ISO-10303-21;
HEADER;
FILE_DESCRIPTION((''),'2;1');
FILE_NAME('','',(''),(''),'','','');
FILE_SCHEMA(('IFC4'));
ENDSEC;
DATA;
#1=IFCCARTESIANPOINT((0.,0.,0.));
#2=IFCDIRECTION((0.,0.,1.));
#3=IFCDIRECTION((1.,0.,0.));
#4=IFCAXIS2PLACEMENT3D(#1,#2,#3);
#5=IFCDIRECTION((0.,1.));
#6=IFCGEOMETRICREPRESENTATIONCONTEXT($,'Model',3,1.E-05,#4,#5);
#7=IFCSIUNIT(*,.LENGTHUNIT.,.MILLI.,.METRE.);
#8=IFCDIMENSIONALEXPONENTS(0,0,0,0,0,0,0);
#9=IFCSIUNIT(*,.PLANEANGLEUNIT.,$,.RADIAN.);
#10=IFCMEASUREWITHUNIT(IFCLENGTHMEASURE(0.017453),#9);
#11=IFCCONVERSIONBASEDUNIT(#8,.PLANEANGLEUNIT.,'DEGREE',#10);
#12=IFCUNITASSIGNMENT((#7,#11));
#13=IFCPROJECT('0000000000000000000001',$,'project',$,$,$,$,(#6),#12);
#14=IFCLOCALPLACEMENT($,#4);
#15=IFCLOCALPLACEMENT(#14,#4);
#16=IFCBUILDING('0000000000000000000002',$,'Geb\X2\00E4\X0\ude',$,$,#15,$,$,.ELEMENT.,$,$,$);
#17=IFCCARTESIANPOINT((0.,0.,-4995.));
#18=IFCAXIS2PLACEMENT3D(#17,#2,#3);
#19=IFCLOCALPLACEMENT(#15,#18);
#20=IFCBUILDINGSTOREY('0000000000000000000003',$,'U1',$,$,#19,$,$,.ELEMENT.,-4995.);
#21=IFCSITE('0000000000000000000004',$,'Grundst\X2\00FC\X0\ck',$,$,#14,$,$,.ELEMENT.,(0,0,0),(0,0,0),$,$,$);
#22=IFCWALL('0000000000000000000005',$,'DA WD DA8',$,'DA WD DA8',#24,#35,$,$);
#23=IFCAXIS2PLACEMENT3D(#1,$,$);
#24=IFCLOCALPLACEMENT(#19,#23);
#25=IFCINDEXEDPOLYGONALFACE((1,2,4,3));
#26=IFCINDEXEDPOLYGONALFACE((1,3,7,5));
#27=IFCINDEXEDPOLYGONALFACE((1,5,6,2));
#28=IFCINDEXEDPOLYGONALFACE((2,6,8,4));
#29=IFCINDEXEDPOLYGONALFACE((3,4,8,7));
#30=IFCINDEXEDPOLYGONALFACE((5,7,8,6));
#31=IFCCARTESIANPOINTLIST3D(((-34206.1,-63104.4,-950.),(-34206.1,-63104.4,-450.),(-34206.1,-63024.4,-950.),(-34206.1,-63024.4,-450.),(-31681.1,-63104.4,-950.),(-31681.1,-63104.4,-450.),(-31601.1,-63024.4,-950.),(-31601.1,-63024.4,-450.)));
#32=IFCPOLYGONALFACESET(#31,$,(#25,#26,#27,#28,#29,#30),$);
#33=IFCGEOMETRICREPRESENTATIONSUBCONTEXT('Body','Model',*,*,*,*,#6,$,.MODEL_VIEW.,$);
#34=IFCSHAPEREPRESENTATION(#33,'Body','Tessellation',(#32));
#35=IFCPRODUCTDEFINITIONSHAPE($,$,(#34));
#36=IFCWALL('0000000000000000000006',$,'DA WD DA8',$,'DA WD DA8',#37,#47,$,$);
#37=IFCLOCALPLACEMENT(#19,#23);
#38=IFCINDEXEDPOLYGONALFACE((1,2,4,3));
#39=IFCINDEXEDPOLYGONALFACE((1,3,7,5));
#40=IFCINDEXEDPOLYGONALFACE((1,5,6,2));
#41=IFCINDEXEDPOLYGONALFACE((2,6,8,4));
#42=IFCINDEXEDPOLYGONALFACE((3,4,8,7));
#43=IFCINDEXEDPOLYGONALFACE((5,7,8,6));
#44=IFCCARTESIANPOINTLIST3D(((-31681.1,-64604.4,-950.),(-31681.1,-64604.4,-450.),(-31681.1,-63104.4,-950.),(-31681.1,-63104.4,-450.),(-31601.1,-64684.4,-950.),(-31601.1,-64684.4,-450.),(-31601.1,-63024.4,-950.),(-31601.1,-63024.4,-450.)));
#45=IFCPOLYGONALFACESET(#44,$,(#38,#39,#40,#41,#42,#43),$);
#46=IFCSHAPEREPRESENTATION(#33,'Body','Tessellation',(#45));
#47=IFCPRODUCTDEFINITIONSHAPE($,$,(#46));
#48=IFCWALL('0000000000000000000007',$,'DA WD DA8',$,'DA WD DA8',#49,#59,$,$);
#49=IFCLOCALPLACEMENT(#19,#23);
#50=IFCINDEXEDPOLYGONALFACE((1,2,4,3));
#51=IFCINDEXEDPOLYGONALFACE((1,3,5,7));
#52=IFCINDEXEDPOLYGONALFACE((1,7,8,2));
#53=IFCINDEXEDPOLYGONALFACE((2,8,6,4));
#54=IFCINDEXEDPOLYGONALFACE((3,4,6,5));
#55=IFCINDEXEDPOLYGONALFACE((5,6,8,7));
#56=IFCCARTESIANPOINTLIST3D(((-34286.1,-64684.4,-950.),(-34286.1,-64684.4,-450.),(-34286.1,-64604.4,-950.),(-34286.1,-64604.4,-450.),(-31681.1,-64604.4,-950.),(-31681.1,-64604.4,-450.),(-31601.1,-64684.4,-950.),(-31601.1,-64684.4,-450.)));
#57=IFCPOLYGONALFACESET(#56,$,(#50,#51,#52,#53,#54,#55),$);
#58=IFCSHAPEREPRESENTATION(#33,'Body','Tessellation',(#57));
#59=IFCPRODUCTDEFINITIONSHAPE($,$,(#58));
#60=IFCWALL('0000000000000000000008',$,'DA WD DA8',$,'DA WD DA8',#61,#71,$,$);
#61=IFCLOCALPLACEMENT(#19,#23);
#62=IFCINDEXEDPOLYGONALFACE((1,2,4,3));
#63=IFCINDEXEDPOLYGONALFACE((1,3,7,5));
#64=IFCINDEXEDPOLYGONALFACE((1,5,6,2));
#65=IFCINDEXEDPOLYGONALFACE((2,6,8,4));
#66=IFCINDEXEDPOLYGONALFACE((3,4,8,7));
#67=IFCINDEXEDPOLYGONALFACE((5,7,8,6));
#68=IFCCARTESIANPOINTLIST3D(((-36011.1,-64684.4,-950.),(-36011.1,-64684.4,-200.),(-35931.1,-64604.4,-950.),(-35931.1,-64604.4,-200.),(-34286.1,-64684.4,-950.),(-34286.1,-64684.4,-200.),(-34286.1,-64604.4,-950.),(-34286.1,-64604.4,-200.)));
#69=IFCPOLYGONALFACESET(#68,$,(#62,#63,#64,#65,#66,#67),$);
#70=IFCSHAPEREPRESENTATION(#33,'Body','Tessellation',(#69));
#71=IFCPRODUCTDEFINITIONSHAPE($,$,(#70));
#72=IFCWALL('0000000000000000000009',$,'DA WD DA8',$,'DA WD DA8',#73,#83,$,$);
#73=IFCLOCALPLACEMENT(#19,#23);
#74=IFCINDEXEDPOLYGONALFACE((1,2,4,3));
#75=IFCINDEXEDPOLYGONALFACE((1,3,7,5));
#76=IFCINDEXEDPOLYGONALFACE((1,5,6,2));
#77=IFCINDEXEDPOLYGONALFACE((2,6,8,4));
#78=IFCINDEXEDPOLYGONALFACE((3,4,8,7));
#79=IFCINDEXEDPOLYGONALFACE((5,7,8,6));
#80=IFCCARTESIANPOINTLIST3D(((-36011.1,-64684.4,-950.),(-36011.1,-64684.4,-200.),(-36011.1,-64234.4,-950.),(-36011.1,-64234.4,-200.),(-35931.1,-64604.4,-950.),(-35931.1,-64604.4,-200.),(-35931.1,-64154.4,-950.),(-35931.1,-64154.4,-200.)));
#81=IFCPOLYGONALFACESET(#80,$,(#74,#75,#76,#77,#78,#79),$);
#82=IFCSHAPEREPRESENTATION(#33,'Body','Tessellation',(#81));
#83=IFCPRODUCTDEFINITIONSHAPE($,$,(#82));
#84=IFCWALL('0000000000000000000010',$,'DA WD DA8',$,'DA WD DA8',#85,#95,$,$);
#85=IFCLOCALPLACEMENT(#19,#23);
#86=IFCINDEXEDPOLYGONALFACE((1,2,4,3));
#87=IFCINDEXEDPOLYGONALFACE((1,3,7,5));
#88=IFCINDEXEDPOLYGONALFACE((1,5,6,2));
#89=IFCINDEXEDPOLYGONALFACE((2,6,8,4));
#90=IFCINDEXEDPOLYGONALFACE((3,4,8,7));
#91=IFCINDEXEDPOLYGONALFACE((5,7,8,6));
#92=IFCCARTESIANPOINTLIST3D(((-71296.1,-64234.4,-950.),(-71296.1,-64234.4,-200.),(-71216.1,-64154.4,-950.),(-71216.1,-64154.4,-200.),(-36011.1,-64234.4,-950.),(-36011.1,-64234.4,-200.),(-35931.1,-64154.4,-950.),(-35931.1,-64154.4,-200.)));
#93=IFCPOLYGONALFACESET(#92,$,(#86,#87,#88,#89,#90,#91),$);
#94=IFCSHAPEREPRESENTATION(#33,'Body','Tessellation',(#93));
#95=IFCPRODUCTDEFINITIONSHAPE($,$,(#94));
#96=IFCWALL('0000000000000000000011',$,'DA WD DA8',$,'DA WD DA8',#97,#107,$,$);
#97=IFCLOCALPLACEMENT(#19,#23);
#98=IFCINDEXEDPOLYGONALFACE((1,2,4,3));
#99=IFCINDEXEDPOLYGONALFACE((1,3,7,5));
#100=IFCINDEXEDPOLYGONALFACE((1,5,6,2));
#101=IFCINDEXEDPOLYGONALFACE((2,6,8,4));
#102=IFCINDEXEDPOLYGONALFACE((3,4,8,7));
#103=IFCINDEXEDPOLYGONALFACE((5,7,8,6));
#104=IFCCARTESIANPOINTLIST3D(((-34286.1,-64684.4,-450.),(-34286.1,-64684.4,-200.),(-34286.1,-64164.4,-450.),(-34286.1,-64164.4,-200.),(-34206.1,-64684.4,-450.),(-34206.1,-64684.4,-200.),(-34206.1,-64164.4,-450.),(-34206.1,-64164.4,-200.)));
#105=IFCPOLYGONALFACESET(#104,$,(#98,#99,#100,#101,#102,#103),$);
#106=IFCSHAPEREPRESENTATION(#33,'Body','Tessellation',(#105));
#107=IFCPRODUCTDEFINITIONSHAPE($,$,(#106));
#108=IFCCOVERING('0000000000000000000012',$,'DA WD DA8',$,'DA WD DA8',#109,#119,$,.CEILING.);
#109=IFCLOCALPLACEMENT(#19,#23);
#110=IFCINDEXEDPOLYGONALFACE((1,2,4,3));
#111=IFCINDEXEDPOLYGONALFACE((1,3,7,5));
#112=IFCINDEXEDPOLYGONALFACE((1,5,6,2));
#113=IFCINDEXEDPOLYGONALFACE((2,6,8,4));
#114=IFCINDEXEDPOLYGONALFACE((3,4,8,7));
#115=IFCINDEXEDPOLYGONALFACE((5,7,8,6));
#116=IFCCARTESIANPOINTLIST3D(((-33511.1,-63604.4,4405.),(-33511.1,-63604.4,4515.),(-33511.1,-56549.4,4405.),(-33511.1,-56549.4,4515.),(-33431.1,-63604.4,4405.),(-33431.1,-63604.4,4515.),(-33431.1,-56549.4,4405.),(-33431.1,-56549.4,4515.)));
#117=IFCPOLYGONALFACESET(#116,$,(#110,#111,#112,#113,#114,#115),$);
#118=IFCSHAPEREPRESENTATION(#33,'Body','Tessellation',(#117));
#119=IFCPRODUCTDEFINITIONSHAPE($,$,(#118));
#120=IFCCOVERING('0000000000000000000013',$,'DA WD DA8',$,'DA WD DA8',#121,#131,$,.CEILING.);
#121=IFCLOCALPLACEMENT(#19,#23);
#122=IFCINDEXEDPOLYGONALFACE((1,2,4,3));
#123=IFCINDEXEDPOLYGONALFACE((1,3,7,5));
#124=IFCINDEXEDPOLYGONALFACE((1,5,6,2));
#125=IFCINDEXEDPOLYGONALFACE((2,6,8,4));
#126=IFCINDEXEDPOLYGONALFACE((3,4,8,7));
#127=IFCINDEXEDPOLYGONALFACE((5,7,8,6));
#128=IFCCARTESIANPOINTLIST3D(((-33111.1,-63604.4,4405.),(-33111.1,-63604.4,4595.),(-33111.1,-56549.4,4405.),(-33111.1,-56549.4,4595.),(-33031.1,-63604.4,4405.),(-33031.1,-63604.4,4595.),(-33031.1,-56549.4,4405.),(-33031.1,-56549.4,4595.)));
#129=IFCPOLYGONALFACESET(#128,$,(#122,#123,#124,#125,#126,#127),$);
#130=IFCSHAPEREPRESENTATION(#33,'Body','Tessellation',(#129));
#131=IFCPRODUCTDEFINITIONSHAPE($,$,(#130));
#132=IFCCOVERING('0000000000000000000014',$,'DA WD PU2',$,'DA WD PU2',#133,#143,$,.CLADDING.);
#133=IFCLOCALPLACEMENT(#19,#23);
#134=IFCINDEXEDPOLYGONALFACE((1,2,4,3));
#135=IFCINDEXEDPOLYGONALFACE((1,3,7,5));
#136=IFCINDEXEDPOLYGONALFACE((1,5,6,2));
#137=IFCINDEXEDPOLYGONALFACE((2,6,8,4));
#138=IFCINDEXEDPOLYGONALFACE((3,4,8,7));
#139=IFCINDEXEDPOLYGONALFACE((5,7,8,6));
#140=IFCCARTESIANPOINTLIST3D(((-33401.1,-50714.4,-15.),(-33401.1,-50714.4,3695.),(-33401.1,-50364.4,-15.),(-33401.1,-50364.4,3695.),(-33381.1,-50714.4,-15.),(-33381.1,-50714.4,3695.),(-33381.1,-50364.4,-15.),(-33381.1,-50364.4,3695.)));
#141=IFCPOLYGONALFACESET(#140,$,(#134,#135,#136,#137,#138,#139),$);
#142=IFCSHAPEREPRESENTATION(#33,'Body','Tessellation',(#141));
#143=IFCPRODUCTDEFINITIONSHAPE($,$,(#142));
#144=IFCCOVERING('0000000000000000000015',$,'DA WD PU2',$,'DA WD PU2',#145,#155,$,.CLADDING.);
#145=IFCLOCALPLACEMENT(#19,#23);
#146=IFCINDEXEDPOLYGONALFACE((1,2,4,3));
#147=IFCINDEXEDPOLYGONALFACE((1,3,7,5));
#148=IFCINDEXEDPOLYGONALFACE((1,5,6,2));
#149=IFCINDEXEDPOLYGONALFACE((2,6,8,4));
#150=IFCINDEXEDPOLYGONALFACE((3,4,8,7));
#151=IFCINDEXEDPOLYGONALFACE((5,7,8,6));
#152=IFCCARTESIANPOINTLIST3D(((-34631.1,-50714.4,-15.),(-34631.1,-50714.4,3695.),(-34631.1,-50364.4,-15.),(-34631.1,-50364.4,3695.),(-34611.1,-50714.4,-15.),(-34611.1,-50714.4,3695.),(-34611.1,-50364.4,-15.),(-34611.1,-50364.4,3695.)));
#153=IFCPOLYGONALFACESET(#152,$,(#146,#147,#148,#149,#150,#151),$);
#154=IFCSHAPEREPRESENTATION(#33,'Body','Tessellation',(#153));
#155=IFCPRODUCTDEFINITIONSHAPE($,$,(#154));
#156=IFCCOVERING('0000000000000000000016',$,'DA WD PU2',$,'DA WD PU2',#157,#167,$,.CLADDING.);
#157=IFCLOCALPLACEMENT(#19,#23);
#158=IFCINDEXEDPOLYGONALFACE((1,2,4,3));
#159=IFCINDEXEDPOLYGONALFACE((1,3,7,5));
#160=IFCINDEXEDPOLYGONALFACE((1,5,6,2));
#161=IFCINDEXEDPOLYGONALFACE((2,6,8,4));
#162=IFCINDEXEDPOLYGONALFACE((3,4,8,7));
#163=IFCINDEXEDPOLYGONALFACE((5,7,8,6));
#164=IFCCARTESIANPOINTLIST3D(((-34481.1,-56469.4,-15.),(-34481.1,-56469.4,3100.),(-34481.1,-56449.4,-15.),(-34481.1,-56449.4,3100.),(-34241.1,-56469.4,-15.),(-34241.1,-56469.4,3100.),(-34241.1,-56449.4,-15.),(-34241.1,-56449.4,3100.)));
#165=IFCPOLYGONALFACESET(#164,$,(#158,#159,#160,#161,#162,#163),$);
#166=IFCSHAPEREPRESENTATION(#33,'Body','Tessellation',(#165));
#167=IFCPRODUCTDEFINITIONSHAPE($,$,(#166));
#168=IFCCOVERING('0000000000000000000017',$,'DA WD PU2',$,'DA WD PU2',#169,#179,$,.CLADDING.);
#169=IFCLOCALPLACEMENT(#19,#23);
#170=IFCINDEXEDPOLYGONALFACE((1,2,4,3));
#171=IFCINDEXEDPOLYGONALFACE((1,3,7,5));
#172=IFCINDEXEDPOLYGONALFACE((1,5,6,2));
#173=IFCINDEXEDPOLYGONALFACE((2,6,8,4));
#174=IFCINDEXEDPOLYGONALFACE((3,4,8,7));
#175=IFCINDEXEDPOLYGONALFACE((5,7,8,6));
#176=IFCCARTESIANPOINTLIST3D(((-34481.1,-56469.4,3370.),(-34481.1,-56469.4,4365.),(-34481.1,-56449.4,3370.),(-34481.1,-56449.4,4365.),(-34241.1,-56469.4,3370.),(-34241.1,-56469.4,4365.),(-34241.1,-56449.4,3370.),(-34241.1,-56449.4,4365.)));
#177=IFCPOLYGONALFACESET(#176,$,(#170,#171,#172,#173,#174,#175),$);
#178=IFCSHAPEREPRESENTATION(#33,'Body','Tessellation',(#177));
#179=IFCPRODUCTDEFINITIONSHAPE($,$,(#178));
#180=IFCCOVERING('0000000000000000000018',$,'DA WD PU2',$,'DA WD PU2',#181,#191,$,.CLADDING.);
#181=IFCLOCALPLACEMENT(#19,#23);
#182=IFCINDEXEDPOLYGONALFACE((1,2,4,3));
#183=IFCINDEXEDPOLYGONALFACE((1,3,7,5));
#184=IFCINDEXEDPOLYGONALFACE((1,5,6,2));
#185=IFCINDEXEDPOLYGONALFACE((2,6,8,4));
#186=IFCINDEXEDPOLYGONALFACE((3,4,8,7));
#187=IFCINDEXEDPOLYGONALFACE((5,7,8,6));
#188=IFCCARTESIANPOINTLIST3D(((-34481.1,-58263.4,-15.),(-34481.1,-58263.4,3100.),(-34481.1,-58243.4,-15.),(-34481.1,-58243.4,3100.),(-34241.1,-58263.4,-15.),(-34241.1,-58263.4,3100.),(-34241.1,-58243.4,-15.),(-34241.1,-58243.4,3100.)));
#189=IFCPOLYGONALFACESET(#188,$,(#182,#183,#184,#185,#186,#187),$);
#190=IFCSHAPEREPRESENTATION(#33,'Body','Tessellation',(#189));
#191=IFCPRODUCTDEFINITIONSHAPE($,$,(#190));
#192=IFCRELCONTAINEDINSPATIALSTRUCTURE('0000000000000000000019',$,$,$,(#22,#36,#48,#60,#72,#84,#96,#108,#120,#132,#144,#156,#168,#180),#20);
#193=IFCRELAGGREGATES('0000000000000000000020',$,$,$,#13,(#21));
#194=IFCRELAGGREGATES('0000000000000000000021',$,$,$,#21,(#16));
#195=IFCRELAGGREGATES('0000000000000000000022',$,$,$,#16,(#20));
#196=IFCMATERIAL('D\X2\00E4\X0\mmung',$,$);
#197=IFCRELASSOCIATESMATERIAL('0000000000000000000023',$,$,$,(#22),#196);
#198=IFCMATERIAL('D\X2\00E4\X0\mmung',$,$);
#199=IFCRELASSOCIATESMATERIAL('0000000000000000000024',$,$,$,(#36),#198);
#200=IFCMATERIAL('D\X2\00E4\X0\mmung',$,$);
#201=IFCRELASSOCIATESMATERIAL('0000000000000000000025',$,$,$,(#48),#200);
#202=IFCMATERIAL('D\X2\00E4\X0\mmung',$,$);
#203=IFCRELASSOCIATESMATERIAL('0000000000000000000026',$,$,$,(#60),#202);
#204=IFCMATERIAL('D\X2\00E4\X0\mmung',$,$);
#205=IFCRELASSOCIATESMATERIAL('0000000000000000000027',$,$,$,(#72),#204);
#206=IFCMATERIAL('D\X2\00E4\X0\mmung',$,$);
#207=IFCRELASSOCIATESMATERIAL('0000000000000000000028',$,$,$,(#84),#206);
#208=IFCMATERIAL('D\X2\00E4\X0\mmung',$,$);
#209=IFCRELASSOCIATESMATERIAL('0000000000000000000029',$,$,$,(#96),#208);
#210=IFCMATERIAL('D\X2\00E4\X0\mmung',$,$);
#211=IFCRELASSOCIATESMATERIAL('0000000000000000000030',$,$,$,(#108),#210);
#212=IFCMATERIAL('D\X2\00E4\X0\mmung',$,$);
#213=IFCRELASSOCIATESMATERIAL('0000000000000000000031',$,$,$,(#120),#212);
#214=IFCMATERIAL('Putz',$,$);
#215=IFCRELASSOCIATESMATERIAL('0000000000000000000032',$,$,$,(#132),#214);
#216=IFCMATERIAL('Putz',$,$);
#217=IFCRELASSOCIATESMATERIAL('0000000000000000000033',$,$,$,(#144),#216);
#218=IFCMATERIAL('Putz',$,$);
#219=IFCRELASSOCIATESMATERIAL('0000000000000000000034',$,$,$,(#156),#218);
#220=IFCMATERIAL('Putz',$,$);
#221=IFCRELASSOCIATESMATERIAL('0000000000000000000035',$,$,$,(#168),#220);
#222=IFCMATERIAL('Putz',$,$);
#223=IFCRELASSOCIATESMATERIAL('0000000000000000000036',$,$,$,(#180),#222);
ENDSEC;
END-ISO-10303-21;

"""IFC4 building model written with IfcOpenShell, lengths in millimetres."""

from ifc_helpers import new_model, entity, si_unit, converted_unit, direction, frame, origin_with_axes, place, context, subcontext, project, spatial, line, indexed_curve, outline, extrude, material, element, save


model = new_model("IFC4")

# Units and contexts
model_context = context("Model", 3, precision=1e-05, world=origin_with_axes(), true_north=direction((0.0, 1.0)))
body_context = subcontext(model_context, "Body", "Model", "MODEL_VIEW")
ifc_project = project(units=[si_unit("LENGTHUNIT", "METRE", prefix="MILLI"), converted_unit("PLANEANGLEUNIT", "DEGREE", entity("IfcLengthMeasure", 0.017453), si_unit("PLANEANGLEUNIT", "RADIAN"), dimensions=[0, 0, 0, 0, 0, 0, 0])], contexts=[model_context])

# Site, building, storey
site_placement = place(None, origin_with_axes())
site = spatial("IfcSite", under=ifc_project, at=site_placement, Name="Grundstück", CompositionType="ELEMENT", RefLatitude=(0, 0, 0), RefLongitude=(0, 0, 0))
building_placement = place(site_placement, origin_with_axes())
building = spatial("IfcBuilding", under=site, at=building_placement, Name="Gebäude", CompositionType="ELEMENT")
storey_placement = place(building_placement, frame((0.0, 0.0, -4995.0), z_axis=(0.0, 0.0, 1.0), x_axis=(1.0, 0.0, 0.0)))
storey = spatial("IfcBuildingStorey", under=building, at=storey_placement, Name="U1", CompositionType="ELEMENT", Elevation=-4995.0)

# Walls
ifc_material_1 = material(Name="Dämmung")
wall_1_placement = place(storey_placement, frame((-34206.1, -63064.4, -950.0), z_axis=(0.0, 0.0, 1.0), x_axis=(1.0, 0.0, 0.0)))
element("IfcWall", 1, at=wall_1_placement, inside=storey, material=ifc_material_1, Name="DA WD DA8", ObjectType="DA WD DA8", context=body_context, shape_type="SweptSolid", body=[
    extrude(outline(indexed_curve([(0.0, -40.0), (0.0, 40.0), (2605.0, 40.0), (2525.0, -40.0)], segments=[line(1, 2), line(2, 3), line(3, 4), line(4, 1)])), origin_with_axes(), (0.0, 0.0, 1.0), 500.0),
])
ifc_material_2 = material(Name="Dämmung")
wall_2_placement = place(storey_placement, frame((-31641.1, -63064.4, -950.0), z_axis=(0.0, 0.0, 1.0), x_axis=(0.0, -1.0, 0.0)))
element("IfcWall", 2, at=wall_2_placement, inside=storey, material=ifc_material_2, Name="DA WD DA8", ObjectType="DA WD DA8", context=body_context, shape_type="SweptSolid", body=[
    extrude(outline(indexed_curve([(40.0, -40.0), (-40.0, 40.0), (1620.0, 40.0), (1540.0, -40.0)], segments=[line(1, 2), line(2, 3), line(3, 4), line(4, 1)])), origin_with_axes(), (0.0, 0.0, 1.0), 500.0),
])
ifc_material_3 = material(Name="Dämmung")
wall_3_placement = place(storey_placement, frame((-31641.1, -64644.4, -950.0), z_axis=(0.0, 0.0, 1.0), x_axis=(-1.0, 0.0, 0.0)))
element("IfcWall", 3, at=wall_3_placement, inside=storey, material=ifc_material_3, Name="DA WD DA8", ObjectType="DA WD DA8", context=body_context, shape_type="SweptSolid", body=[
    extrude(outline(indexed_curve([(40.0, -40.0), (-40.0, 40.0), (2645.0, 40.0), (2645.0, -40.0)], segments=[line(1, 2), line(2, 3), line(3, 4), line(4, 1)])), origin_with_axes(), (0.0, 0.0, 1.0), 500.0),
])
ifc_material_4 = material(Name="Dämmung")
wall_4_placement = place(storey_placement, frame((-34286.1, -64644.4, -950.0), z_axis=(0.0, 0.0, 1.0), x_axis=(-1.0, 0.0, 0.0)))
element("IfcWall", 4, at=wall_4_placement, inside=storey, material=ifc_material_4, Name="DA WD DA8", ObjectType="DA WD DA8", context=body_context, shape_type="SweptSolid", body=[
    extrude(outline(indexed_curve([(0.0, -40.0), (0.0, 40.0), (1725.0, 40.0), (1645.0, -40.0)], segments=[line(1, 2), line(2, 3), line(3, 4), line(4, 1)])), origin_with_axes(), (0.0, 0.0, 1.0), 750.0),
])
ifc_material_5 = material(Name="Dämmung")
wall_5_placement = place(storey_placement, frame((-35971.1, -64644.4, -950.0), z_axis=(0.0, 0.0, 1.0), x_axis=(0.0, 1.0, 0.0)))
element("IfcWall", 5, at=wall_5_placement, inside=storey, material=ifc_material_5, Name="DA WD DA8", ObjectType="DA WD DA8", context=body_context, shape_type="SweptSolid", body=[
    extrude(outline(indexed_curve([(40.0, -40.0), (-40.0, 40.0), (410.0, 40.0), (490.0, -40.0)], segments=[line(1, 2), line(2, 3), line(3, 4), line(4, 1)])), origin_with_axes(), (0.0, 0.0, 1.0), 750.0),
])
ifc_material_6 = material(Name="Dämmung")
wall_6_placement = place(storey_placement, frame((-35971.1, -64194.4, -950.0), z_axis=(0.0, 0.0, 1.0), x_axis=(-1.0, 0.0, 0.0)))
element("IfcWall", 6, at=wall_6_placement, inside=storey, material=ifc_material_6, Name="DA WD DA8", ObjectType="DA WD DA8", context=body_context, shape_type="SweptSolid", body=[
    extrude(outline(indexed_curve([(-40.0, -40.0), (40.0, 40.0), (35325.0, 40.0), (35245.0, -40.0)], segments=[line(1, 2), line(2, 3), line(3, 4), line(4, 1)])), origin_with_axes(), (0.0, 0.0, 1.0), 750.0),
])
ifc_material_7 = material(Name="Dämmung")
wall_7_placement = place(storey_placement, frame((-34246.1, -64164.4, -450.0), z_axis=(0.0, 0.0, 1.0), x_axis=(0.0, -1.0, 0.0)))
element("IfcWall", 7, at=wall_7_placement, inside=storey, material=ifc_material_7, Name="DA WD DA8", ObjectType="DA WD DA8", context=body_context, shape_type="SweptSolid", body=[
    extrude(outline(indexed_curve([(0.0, -40.0), (0.0, 40.0), (520.0, 40.0), (520.0, -40.0)], segments=[line(1, 2), line(2, 3), line(3, 4), line(4, 1)])), origin_with_axes(), (0.0, 0.0, 1.0), 250.0),
])

# Coverings
ifc_material_8 = material(Name="Dämmung")
covering_1_placement = place(storey_placement, frame((-33471.1, -63604.4, 4405.0), z_axis=(0.0, 0.0, 1.0), x_axis=(0.0, 1.0, 0.0)))
element("IfcCovering", 8, at=covering_1_placement, inside=storey, material=ifc_material_8, Name="DA WD DA8", ObjectType="DA WD DA8", PredefinedType="CEILING", context=body_context, shape_type="SweptSolid", body=[
    extrude(outline(indexed_curve([(0.0, -40.0), (0.0, 40.0), (7055.0, 40.0), (7055.0, -40.0)], segments=[line(1, 2), line(2, 3), line(3, 4), line(4, 1)])), origin_with_axes(), (0.0, 0.0, 1.0), 110.0),
])
ifc_material_9 = material(Name="Dämmung")
covering_2_placement = place(storey_placement, frame((-33071.1, -56549.4, 4405.0), z_axis=(0.0, 0.0, 1.0), x_axis=(0.0, -1.0, 0.0)))
element("IfcCovering", 9, at=covering_2_placement, inside=storey, material=ifc_material_9, Name="DA WD DA8", ObjectType="DA WD DA8", PredefinedType="CEILING", context=body_context, shape_type="SweptSolid", body=[
    extrude(outline(indexed_curve([(0.0, -40.0), (0.0, 40.0), (7055.0, 40.0), (7055.0, -40.0)], segments=[line(1, 2), line(2, 3), line(3, 4), line(4, 1)])), origin_with_axes(), (0.0, 0.0, 1.0), 190.0),
])
ifc_material_10 = material(Name="Putz")
covering_3_placement = place(storey_placement, frame((-33391.1, -50714.4, -15.0), z_axis=(0.0, 0.0, 1.0), x_axis=(0.0, 1.0, 0.0)))
element("IfcCovering", 10, at=covering_3_placement, inside=storey, material=ifc_material_10, Name="DA WD PU2", ObjectType="DA WD PU2", PredefinedType="CLADDING", context=body_context, shape_type="SweptSolid", body=[
    extrude(outline(indexed_curve([(0.0, -10.0), (0.0, 10.0), (350.0, 10.0), (350.0, -10.0)], segments=[line(1, 2), line(2, 3), line(3, 4), line(4, 1)])), origin_with_axes(), (0.0, 0.0, 1.0), 3710.0),
])
ifc_material_11 = material(Name="Putz")
covering_4_placement = place(storey_placement, frame((-34621.1, -50714.4, -15.0), z_axis=(0.0, 0.0, 1.0), x_axis=(0.0, 1.0, 0.0)))
element("IfcCovering", 11, at=covering_4_placement, inside=storey, material=ifc_material_11, Name="DA WD PU2", ObjectType="DA WD PU2", PredefinedType="CLADDING", context=body_context, shape_type="SweptSolid", body=[
    extrude(outline(indexed_curve([(0.0, -10.0), (0.0, 10.0), (350.0, 10.0), (350.0, -10.0)], segments=[line(1, 2), line(2, 3), line(3, 4), line(4, 1)])), origin_with_axes(), (0.0, 0.0, 1.0), 3710.0),
])
ifc_material_12 = material(Name="Putz")
covering_5_placement = place(storey_placement, frame((-34241.1, -56459.4, -15.0), z_axis=(0.0, 0.0, 1.0), x_axis=(-1.0, 0.0, 0.0)))
element("IfcCovering", 12, at=covering_5_placement, inside=storey, material=ifc_material_12, Name="DA WD PU2", ObjectType="DA WD PU2", PredefinedType="CLADDING", context=body_context, shape_type="SweptSolid", body=[
    extrude(outline(indexed_curve([(0.0, -10.0), (0.0, 10.0), (240.0, 10.0), (240.0, -10.0)], segments=[line(1, 2), line(2, 3), line(3, 4), line(4, 1)])), origin_with_axes(), (0.0, 0.0, 1.0), 3115.0),
])
ifc_material_13 = material(Name="Putz")
covering_6_placement = place(storey_placement, frame((-34241.1, -56459.4, 3370.0), z_axis=(0.0, 0.0, 1.0), x_axis=(-1.0, 0.0, 0.0)))
element("IfcCovering", 13, at=covering_6_placement, inside=storey, material=ifc_material_13, Name="DA WD PU2", ObjectType="DA WD PU2", PredefinedType="CLADDING", context=body_context, shape_type="SweptSolid", body=[
    extrude(outline(indexed_curve([(0.0, -10.0), (0.0, 10.0), (240.0, 10.0), (240.0, -10.0)], segments=[line(1, 2), line(2, 3), line(3, 4), line(4, 1)])), origin_with_axes(), (0.0, 0.0, 1.0), 995.0),
])
ifc_material_14 = material(Name="Putz")
covering_7_placement = place(storey_placement, frame((-34241.1, -58253.4, -15.0), z_axis=(0.0, 0.0, 1.0), x_axis=(-1.0, 0.0, 0.0)))
element("IfcCovering", 14, at=covering_7_placement, inside=storey, material=ifc_material_14, Name="DA WD PU2", ObjectType="DA WD PU2", PredefinedType="CLADDING", context=body_context, shape_type="SweptSolid", body=[
    extrude(outline(indexed_curve([(0.0, -10.0), (0.0, 10.0), (240.0, 10.0), (240.0, -10.0)], segments=[line(1, 2), line(2, 3), line(3, 4), line(4, 1)])), origin_with_axes(), (0.0, 0.0, 1.0), 3115.0),
])

save(model, "model.ifc")
